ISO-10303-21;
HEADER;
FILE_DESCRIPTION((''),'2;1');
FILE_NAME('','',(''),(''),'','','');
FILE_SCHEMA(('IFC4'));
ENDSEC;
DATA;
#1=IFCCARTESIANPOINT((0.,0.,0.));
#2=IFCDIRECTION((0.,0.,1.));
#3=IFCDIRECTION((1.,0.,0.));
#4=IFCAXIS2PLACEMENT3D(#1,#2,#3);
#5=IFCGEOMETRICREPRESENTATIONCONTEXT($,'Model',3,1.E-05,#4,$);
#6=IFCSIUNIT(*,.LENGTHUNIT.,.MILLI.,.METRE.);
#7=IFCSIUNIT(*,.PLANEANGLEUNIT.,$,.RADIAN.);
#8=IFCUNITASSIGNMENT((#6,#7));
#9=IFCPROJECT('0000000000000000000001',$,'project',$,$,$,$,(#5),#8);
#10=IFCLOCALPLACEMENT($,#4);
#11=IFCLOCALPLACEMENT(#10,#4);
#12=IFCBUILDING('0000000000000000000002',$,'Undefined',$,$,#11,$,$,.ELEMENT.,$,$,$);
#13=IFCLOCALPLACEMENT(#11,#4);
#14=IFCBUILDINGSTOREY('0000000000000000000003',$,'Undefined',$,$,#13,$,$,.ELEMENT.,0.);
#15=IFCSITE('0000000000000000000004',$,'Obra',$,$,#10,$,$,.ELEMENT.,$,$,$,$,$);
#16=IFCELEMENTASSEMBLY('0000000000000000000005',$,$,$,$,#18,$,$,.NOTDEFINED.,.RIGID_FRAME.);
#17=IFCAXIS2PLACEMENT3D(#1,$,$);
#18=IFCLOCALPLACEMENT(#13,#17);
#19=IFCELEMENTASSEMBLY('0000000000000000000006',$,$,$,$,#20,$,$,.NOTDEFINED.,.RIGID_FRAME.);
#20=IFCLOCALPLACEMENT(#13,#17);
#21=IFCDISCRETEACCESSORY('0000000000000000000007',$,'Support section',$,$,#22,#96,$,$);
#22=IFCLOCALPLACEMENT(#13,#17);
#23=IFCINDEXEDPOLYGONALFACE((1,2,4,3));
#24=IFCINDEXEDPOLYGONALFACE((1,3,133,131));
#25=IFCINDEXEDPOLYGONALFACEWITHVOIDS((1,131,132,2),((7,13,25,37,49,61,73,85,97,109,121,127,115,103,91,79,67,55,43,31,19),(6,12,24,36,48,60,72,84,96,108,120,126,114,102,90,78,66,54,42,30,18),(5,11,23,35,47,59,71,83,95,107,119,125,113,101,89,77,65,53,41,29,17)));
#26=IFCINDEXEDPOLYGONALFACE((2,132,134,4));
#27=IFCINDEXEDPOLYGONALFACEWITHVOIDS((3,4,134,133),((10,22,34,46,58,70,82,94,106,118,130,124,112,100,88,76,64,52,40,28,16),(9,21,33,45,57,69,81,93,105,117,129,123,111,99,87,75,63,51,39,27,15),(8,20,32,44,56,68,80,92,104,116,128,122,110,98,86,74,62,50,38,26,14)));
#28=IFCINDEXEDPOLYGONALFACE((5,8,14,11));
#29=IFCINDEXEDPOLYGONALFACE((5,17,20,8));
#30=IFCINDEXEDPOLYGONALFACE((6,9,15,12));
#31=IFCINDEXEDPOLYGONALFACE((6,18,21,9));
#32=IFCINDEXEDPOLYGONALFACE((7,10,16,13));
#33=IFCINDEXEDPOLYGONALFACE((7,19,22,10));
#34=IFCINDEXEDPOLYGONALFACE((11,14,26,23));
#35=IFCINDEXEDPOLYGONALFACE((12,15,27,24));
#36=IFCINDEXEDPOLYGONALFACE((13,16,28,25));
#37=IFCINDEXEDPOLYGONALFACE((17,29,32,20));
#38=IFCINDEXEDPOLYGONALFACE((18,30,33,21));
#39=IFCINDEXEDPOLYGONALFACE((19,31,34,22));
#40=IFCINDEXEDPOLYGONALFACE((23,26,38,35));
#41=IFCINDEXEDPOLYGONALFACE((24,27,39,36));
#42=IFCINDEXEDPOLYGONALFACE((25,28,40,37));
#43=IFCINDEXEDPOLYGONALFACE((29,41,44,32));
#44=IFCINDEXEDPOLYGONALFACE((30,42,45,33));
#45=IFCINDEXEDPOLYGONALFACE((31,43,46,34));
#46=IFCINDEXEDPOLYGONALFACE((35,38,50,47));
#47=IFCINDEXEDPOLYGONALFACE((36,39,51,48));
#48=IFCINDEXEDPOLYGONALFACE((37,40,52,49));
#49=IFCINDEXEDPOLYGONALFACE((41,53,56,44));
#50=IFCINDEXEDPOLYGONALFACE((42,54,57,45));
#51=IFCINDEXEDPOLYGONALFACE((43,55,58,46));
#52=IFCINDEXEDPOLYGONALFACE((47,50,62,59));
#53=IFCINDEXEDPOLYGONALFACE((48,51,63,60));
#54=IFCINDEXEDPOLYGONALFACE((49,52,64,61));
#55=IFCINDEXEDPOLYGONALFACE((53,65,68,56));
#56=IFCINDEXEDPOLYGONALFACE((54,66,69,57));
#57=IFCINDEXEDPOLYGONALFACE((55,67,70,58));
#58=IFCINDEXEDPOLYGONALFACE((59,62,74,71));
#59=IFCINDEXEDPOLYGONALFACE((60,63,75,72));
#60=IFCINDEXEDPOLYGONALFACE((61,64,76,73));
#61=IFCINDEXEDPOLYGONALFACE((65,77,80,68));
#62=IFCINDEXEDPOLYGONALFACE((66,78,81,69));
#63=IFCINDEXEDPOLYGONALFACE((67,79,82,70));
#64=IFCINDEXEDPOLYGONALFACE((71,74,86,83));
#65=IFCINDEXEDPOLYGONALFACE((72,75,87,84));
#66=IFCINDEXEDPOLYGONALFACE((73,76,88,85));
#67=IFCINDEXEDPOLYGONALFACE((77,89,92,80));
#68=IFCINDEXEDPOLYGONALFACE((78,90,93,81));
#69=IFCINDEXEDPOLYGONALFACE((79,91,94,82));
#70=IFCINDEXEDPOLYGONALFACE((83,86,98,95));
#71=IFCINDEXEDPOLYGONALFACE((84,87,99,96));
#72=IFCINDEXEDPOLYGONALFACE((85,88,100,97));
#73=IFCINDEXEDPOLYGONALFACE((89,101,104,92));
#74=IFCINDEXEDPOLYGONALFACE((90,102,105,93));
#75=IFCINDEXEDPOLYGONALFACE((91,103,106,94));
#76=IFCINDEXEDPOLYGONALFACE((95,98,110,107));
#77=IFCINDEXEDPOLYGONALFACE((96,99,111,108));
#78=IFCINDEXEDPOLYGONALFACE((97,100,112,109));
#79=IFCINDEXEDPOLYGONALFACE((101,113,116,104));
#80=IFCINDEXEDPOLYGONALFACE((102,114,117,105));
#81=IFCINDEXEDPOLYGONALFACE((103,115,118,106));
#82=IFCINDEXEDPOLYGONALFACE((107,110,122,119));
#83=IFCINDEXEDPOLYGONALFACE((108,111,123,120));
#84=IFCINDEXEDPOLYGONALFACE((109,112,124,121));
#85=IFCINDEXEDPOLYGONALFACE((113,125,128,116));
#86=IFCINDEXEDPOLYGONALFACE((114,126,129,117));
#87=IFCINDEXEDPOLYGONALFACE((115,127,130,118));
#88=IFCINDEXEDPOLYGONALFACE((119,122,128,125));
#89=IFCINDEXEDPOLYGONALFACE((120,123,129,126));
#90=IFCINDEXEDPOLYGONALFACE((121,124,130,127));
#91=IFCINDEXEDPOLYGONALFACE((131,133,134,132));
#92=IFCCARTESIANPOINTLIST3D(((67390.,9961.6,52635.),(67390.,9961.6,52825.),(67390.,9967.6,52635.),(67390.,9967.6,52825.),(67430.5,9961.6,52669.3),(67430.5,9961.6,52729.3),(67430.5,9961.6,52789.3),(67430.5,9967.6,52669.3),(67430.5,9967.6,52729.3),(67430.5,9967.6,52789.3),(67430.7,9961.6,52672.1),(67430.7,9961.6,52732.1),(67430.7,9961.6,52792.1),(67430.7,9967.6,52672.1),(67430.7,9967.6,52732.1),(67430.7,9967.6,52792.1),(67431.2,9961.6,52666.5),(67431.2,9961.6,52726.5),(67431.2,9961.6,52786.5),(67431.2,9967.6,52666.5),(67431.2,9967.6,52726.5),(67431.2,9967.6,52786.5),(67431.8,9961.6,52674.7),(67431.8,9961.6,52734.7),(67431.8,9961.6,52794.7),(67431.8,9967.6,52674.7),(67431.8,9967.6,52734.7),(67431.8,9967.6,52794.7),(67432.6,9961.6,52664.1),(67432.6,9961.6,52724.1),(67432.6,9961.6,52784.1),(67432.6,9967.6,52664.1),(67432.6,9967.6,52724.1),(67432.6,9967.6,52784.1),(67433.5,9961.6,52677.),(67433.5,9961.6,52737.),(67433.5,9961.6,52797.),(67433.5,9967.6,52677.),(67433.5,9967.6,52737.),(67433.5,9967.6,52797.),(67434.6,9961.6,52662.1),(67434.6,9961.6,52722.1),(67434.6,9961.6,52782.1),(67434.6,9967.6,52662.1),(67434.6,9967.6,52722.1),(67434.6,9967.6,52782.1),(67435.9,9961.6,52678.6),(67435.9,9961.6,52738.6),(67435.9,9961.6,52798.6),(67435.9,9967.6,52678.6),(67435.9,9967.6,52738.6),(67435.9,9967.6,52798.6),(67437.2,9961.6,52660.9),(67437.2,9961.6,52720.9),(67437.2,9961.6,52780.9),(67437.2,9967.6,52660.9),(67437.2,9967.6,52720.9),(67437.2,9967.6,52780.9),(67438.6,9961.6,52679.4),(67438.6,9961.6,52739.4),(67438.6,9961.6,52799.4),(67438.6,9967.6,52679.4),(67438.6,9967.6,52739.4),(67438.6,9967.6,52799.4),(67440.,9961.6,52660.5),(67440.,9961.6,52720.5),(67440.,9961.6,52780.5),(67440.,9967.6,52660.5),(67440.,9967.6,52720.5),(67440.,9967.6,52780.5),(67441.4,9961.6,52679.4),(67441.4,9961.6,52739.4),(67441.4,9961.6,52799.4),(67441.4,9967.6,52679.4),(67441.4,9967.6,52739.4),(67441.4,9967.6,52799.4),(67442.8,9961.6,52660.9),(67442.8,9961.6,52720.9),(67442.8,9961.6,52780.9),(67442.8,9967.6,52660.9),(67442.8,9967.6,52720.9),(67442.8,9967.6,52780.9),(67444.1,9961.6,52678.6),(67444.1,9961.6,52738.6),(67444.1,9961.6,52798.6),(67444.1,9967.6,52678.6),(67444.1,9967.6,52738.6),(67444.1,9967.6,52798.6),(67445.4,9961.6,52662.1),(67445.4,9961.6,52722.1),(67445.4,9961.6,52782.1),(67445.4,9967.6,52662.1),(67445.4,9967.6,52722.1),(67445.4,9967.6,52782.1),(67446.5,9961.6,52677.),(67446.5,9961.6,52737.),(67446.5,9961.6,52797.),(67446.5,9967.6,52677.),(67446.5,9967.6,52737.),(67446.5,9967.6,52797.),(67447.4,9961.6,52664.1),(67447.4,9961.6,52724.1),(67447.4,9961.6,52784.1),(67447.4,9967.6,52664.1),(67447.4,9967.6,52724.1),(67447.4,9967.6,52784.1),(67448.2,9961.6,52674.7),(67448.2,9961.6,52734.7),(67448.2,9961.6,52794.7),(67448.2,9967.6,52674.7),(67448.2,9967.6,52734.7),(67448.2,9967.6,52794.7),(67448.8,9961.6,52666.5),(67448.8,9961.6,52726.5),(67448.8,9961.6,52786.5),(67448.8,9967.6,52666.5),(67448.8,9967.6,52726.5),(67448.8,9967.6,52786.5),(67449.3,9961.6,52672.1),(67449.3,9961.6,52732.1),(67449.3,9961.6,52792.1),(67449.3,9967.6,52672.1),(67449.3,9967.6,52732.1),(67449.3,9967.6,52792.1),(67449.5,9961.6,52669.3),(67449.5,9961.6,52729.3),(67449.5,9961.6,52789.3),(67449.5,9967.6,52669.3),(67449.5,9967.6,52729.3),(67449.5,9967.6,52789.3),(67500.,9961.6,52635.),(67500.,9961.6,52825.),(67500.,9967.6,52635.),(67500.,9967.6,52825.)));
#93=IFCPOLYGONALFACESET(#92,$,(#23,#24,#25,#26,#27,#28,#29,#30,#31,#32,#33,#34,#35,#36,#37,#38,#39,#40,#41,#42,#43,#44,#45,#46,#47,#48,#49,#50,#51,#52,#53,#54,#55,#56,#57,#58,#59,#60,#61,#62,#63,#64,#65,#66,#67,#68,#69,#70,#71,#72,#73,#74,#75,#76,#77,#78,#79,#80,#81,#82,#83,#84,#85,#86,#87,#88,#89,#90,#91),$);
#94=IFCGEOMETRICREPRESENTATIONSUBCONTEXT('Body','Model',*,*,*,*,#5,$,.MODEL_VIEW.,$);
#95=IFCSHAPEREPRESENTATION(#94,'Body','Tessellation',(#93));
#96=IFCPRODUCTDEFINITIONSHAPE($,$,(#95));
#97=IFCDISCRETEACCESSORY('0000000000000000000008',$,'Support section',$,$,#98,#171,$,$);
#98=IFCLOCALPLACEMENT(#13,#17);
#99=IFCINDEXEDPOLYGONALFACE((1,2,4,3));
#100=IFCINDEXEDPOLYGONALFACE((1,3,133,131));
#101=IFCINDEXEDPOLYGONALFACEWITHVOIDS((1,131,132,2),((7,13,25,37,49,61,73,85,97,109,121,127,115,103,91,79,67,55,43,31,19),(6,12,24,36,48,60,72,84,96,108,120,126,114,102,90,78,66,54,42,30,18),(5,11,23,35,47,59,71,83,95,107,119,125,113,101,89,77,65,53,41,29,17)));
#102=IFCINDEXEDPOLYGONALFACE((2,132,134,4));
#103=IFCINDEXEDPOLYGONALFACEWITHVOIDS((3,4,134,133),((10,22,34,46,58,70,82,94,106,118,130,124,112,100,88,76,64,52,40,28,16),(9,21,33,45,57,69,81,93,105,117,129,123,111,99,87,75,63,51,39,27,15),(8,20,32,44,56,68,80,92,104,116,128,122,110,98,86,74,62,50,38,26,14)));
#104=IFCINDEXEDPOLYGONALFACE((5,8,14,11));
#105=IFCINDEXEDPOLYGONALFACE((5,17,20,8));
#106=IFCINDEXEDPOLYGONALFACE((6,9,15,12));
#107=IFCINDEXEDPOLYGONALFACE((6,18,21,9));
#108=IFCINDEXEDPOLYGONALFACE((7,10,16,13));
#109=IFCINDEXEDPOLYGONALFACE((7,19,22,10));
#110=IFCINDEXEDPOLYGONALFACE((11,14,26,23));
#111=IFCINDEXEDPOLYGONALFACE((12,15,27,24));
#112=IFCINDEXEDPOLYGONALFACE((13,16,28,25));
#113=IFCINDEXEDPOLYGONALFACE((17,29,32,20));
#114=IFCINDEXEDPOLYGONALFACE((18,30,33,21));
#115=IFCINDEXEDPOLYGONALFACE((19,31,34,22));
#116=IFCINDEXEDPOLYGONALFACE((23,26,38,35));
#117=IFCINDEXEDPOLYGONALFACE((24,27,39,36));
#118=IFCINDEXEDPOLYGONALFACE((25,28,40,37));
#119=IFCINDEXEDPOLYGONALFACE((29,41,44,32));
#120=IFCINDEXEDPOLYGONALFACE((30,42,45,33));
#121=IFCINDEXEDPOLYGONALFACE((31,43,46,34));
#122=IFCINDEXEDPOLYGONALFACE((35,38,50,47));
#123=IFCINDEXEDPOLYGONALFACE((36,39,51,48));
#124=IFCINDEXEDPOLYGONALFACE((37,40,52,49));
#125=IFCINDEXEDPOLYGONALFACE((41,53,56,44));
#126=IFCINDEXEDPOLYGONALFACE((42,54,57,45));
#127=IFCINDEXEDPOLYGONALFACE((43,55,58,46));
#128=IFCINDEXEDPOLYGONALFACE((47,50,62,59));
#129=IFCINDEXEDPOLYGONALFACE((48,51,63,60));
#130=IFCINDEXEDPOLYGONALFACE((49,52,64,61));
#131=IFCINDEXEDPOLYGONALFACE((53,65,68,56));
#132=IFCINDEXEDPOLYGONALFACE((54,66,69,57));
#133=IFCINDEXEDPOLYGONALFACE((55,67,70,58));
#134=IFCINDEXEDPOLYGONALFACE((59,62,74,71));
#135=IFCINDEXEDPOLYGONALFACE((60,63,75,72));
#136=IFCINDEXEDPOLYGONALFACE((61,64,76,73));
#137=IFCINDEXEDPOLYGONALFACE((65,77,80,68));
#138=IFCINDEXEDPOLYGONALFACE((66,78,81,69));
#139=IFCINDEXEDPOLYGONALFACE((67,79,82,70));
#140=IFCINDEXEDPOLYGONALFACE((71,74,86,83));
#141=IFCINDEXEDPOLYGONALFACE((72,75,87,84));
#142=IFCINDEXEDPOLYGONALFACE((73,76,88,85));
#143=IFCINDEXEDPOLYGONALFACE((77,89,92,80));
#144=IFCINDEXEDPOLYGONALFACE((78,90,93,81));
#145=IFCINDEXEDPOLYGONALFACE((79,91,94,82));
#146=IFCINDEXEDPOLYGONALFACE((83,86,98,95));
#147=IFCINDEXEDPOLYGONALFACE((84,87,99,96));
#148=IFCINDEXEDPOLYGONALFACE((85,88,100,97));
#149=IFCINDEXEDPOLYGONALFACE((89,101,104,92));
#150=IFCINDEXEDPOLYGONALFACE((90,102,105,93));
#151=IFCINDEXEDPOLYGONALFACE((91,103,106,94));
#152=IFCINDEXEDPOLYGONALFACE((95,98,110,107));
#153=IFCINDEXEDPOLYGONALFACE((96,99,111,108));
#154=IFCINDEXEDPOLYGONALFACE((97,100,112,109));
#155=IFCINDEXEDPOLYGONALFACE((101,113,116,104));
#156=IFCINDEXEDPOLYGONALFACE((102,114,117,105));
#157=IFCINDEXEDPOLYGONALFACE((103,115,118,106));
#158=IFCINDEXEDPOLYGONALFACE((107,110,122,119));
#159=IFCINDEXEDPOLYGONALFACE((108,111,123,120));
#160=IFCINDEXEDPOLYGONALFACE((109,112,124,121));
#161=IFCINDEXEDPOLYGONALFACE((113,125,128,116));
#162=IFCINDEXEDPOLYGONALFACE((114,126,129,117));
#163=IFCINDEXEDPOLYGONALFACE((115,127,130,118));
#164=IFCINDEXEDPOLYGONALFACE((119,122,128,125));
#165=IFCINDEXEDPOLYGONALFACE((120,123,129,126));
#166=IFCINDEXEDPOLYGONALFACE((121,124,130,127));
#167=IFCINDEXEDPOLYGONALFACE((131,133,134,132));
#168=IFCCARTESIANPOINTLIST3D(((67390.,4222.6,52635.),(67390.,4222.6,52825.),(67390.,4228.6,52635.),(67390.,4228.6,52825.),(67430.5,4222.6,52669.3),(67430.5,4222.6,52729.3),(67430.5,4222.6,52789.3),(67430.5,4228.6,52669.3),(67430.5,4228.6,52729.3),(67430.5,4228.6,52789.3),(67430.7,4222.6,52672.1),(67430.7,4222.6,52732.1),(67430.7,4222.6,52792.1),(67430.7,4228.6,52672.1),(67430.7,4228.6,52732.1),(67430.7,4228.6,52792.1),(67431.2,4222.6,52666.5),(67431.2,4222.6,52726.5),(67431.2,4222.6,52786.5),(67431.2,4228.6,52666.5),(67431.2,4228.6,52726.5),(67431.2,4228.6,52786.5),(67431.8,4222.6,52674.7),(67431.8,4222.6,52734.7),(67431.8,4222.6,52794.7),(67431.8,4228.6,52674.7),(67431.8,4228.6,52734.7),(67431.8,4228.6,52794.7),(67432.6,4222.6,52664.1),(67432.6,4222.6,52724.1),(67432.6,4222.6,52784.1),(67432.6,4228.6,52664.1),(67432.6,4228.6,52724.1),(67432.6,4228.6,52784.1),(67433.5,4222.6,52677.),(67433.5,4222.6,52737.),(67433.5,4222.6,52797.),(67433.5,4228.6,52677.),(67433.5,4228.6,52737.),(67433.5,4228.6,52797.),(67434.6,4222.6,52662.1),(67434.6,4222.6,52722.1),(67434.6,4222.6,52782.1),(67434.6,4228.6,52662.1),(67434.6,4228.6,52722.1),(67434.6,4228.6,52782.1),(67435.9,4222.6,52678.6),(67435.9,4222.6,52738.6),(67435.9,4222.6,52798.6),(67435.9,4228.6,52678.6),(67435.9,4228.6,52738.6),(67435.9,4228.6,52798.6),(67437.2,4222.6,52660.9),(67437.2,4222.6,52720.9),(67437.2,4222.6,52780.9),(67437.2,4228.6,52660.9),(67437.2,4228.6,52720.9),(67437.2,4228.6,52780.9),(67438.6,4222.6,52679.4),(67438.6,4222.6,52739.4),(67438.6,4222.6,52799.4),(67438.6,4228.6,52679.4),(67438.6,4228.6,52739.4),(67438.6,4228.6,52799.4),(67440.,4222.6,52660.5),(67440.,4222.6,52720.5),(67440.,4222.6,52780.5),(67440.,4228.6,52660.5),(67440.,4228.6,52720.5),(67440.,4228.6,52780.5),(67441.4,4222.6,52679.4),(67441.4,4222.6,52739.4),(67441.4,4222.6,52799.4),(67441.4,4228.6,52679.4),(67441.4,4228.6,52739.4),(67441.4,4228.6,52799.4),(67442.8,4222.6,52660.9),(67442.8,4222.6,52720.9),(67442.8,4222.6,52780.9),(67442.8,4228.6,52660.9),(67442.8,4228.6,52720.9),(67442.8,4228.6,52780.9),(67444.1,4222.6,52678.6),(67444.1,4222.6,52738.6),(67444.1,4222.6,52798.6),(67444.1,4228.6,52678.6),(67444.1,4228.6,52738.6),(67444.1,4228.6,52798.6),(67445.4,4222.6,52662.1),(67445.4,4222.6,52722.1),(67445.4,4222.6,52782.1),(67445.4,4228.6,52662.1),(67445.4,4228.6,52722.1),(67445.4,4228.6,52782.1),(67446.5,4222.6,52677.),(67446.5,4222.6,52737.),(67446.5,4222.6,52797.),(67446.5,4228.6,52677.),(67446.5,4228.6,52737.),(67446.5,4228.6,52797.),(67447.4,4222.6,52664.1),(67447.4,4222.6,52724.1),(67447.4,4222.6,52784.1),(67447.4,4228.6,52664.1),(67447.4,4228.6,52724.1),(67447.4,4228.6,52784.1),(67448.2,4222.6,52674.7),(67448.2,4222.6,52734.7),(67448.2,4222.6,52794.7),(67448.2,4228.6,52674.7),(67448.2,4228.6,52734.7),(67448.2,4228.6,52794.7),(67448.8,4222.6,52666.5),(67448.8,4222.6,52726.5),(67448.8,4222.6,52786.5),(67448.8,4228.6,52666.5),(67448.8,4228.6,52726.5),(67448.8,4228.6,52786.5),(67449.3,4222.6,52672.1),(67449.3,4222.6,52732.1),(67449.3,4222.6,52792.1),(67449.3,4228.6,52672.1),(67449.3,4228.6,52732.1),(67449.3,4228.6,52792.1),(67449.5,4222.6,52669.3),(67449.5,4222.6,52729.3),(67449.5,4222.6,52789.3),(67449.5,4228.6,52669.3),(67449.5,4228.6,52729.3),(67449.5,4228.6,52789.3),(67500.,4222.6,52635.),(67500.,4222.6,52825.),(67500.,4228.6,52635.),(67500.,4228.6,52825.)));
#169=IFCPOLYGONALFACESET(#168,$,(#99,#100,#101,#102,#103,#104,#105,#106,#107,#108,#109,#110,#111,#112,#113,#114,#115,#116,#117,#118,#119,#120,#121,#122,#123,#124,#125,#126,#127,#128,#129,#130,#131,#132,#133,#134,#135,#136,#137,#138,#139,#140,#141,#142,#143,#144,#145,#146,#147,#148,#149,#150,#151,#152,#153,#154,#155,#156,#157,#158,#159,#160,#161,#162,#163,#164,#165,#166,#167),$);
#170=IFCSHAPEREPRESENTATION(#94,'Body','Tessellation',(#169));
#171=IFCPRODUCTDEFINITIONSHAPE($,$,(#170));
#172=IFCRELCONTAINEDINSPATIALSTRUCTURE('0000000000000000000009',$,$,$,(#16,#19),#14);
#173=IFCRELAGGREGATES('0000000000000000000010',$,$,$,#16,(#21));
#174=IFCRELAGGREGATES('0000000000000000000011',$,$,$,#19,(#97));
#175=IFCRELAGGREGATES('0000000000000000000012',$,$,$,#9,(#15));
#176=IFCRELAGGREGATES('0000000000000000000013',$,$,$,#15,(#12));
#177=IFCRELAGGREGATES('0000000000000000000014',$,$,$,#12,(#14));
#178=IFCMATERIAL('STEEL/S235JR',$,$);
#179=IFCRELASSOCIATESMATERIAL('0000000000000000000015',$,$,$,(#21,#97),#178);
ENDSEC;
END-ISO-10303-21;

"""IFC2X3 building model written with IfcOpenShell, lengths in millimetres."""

from ifc_helpers import new_model, si_unit, frame, origin_with_axes, origin_2d_with_axis, place, context, subcontext, project, spatial, rectangle, circle, extrude, source, transform, mapped, material, element, aggregate, save


model = new_model("IFC2X3")

# Units and contexts
model_context = context("Model", 3, precision=1e-05, world=origin_with_axes())
body_context = subcontext(model_context, "Body", "Model", "MODEL_VIEW")
ifc_project = project(units=[si_unit("LENGTHUNIT", "METRE", prefix="MILLI"), si_unit("PLANEANGLEUNIT", "RADIAN")], contexts=[model_context])

# Site, building, storey
site_placement = place(None, origin_with_axes())
site = spatial("IfcSite", under=ifc_project, at=site_placement, Name="Obra", CompositionType="ELEMENT")
building_placement = place(site_placement, origin_with_axes())
building = spatial("IfcBuilding", under=site, at=building_placement, Name="Undefined", CompositionType="ELEMENT")
storey_placement = place(building_placement, origin_with_axes())
storey = spatial("IfcBuildingStorey", under=building, at=storey_placement, Name="Undefined", CompositionType="ELEMENT", Elevation=0.0)

# Element assemblies
assembly_1_placement = place(storey_placement, origin_with_axes())
assembly_1 = element("IfcElementAssembly", 1, at=assembly_1_placement, inside=storey, AssemblyPlace="NOTDEFINED", PredefinedType="RIGID_FRAME")
ifc_material_1 = material(Name="STEEL/S235JR")
assembly_2_placement = place(storey_placement, origin_with_axes())
assembly_2 = element("IfcElementAssembly", 2, at=assembly_2_placement, inside=storey, AssemblyPlace="NOTDEFINED", PredefinedType="RIGID_FRAME")

# Discrete accessories, openings
discrete_accessory_1_placement = place(assembly_1_placement, frame((67445.0, 9964.6, 52635.0), z_axis=(0.0, 0.0, 1.0), x_axis=(1.0, 0.0, 0.0)))
discrete_accessory_1 = element("IfcDiscreteAccessory", 3, at=discrete_accessory_1_placement, material=ifc_material_1, Name="Support section", context=body_context, shape_type="SweptSolid", body=[
    extrude(rectangle(XDim=6.0, YDim=110.0, at=origin_2d_with_axis()), frame((0.0, 0.0, 190.0), z_axis=(0.0, 0.0, -1.0), x_axis=(0.0, 1.0, 0.0)), (0.0, 0.0, 1.0), 190.0),
])
shared_shape_1 = source(origin_with_axes(), body_context, "Body", "SweptSolid", [
    extrude(circle(Radius=9.5, at=origin_2d_with_axis()), frame((0.0, -9.2, 0.0), z_axis=(0.0, 1.0, 0.0), x_axis=(1.0, 0.0, 0.0)), (0.0, 0.0, 1.0), 6.2),
])
opening_1_placement = place(assembly_1_placement, frame((67490.0, 9958.5, 52850.0), z_axis=(-1.0, 0.0, 0.0), x_axis=(0.0, 0.0, -1.0)))
element("IfcOpeningElement", 4, at=opening_1_placement, cuts=discrete_accessory_1, ObjectType="Opening", context=body_context, shape_type="MappedRepresentation", body=[
    mapped(shared_shape_1, transform((60.0, 0.0, 50.0))),
    mapped(shared_shape_1, transform((120.0, 0.0, 50.0))),
    mapped(shared_shape_1, transform((180.0, 0.0, 50.0))),
])
aggregate(assembly_1, [discrete_accessory_1])
discrete_accessory_2_placement = place(assembly_2_placement, frame((67445.0, 4225.6, 52635.0), z_axis=(0.0, 0.0, 1.0), x_axis=(1.0, 0.0, 0.0)))
discrete_accessory_2 = element("IfcDiscreteAccessory", 5, at=discrete_accessory_2_placement, material=ifc_material_1, Name="Support section", context=body_context, shape_type="SweptSolid", body=[
    extrude(rectangle(XDim=6.0, YDim=110.0, at=origin_2d_with_axis()), frame((0.0, 0.0, 190.0), z_axis=(0.0, 0.0, -1.0), x_axis=(0.0, 1.0, 0.0)), (0.0, 0.0, 1.0), 190.0),
])
opening_2_placement = place(assembly_2_placement, frame((67490.0, 4219.5, 52850.0), z_axis=(-1.0, 0.0, 0.0), x_axis=(0.0, 0.0, -1.0)))
element("IfcOpeningElement", 6, at=opening_2_placement, cuts=discrete_accessory_2, ObjectType="Opening", context=body_context, shape_type="MappedRepresentation", body=[
    mapped(shared_shape_1, transform((60.0, 0.0, 50.0))),
    mapped(shared_shape_1, transform((120.0, 0.0, 50.0))),
    mapped(shared_shape_1, transform((180.0, 0.0, 50.0))),
])
aggregate(assembly_2, [discrete_accessory_2])

save(model, "model.ifc")
